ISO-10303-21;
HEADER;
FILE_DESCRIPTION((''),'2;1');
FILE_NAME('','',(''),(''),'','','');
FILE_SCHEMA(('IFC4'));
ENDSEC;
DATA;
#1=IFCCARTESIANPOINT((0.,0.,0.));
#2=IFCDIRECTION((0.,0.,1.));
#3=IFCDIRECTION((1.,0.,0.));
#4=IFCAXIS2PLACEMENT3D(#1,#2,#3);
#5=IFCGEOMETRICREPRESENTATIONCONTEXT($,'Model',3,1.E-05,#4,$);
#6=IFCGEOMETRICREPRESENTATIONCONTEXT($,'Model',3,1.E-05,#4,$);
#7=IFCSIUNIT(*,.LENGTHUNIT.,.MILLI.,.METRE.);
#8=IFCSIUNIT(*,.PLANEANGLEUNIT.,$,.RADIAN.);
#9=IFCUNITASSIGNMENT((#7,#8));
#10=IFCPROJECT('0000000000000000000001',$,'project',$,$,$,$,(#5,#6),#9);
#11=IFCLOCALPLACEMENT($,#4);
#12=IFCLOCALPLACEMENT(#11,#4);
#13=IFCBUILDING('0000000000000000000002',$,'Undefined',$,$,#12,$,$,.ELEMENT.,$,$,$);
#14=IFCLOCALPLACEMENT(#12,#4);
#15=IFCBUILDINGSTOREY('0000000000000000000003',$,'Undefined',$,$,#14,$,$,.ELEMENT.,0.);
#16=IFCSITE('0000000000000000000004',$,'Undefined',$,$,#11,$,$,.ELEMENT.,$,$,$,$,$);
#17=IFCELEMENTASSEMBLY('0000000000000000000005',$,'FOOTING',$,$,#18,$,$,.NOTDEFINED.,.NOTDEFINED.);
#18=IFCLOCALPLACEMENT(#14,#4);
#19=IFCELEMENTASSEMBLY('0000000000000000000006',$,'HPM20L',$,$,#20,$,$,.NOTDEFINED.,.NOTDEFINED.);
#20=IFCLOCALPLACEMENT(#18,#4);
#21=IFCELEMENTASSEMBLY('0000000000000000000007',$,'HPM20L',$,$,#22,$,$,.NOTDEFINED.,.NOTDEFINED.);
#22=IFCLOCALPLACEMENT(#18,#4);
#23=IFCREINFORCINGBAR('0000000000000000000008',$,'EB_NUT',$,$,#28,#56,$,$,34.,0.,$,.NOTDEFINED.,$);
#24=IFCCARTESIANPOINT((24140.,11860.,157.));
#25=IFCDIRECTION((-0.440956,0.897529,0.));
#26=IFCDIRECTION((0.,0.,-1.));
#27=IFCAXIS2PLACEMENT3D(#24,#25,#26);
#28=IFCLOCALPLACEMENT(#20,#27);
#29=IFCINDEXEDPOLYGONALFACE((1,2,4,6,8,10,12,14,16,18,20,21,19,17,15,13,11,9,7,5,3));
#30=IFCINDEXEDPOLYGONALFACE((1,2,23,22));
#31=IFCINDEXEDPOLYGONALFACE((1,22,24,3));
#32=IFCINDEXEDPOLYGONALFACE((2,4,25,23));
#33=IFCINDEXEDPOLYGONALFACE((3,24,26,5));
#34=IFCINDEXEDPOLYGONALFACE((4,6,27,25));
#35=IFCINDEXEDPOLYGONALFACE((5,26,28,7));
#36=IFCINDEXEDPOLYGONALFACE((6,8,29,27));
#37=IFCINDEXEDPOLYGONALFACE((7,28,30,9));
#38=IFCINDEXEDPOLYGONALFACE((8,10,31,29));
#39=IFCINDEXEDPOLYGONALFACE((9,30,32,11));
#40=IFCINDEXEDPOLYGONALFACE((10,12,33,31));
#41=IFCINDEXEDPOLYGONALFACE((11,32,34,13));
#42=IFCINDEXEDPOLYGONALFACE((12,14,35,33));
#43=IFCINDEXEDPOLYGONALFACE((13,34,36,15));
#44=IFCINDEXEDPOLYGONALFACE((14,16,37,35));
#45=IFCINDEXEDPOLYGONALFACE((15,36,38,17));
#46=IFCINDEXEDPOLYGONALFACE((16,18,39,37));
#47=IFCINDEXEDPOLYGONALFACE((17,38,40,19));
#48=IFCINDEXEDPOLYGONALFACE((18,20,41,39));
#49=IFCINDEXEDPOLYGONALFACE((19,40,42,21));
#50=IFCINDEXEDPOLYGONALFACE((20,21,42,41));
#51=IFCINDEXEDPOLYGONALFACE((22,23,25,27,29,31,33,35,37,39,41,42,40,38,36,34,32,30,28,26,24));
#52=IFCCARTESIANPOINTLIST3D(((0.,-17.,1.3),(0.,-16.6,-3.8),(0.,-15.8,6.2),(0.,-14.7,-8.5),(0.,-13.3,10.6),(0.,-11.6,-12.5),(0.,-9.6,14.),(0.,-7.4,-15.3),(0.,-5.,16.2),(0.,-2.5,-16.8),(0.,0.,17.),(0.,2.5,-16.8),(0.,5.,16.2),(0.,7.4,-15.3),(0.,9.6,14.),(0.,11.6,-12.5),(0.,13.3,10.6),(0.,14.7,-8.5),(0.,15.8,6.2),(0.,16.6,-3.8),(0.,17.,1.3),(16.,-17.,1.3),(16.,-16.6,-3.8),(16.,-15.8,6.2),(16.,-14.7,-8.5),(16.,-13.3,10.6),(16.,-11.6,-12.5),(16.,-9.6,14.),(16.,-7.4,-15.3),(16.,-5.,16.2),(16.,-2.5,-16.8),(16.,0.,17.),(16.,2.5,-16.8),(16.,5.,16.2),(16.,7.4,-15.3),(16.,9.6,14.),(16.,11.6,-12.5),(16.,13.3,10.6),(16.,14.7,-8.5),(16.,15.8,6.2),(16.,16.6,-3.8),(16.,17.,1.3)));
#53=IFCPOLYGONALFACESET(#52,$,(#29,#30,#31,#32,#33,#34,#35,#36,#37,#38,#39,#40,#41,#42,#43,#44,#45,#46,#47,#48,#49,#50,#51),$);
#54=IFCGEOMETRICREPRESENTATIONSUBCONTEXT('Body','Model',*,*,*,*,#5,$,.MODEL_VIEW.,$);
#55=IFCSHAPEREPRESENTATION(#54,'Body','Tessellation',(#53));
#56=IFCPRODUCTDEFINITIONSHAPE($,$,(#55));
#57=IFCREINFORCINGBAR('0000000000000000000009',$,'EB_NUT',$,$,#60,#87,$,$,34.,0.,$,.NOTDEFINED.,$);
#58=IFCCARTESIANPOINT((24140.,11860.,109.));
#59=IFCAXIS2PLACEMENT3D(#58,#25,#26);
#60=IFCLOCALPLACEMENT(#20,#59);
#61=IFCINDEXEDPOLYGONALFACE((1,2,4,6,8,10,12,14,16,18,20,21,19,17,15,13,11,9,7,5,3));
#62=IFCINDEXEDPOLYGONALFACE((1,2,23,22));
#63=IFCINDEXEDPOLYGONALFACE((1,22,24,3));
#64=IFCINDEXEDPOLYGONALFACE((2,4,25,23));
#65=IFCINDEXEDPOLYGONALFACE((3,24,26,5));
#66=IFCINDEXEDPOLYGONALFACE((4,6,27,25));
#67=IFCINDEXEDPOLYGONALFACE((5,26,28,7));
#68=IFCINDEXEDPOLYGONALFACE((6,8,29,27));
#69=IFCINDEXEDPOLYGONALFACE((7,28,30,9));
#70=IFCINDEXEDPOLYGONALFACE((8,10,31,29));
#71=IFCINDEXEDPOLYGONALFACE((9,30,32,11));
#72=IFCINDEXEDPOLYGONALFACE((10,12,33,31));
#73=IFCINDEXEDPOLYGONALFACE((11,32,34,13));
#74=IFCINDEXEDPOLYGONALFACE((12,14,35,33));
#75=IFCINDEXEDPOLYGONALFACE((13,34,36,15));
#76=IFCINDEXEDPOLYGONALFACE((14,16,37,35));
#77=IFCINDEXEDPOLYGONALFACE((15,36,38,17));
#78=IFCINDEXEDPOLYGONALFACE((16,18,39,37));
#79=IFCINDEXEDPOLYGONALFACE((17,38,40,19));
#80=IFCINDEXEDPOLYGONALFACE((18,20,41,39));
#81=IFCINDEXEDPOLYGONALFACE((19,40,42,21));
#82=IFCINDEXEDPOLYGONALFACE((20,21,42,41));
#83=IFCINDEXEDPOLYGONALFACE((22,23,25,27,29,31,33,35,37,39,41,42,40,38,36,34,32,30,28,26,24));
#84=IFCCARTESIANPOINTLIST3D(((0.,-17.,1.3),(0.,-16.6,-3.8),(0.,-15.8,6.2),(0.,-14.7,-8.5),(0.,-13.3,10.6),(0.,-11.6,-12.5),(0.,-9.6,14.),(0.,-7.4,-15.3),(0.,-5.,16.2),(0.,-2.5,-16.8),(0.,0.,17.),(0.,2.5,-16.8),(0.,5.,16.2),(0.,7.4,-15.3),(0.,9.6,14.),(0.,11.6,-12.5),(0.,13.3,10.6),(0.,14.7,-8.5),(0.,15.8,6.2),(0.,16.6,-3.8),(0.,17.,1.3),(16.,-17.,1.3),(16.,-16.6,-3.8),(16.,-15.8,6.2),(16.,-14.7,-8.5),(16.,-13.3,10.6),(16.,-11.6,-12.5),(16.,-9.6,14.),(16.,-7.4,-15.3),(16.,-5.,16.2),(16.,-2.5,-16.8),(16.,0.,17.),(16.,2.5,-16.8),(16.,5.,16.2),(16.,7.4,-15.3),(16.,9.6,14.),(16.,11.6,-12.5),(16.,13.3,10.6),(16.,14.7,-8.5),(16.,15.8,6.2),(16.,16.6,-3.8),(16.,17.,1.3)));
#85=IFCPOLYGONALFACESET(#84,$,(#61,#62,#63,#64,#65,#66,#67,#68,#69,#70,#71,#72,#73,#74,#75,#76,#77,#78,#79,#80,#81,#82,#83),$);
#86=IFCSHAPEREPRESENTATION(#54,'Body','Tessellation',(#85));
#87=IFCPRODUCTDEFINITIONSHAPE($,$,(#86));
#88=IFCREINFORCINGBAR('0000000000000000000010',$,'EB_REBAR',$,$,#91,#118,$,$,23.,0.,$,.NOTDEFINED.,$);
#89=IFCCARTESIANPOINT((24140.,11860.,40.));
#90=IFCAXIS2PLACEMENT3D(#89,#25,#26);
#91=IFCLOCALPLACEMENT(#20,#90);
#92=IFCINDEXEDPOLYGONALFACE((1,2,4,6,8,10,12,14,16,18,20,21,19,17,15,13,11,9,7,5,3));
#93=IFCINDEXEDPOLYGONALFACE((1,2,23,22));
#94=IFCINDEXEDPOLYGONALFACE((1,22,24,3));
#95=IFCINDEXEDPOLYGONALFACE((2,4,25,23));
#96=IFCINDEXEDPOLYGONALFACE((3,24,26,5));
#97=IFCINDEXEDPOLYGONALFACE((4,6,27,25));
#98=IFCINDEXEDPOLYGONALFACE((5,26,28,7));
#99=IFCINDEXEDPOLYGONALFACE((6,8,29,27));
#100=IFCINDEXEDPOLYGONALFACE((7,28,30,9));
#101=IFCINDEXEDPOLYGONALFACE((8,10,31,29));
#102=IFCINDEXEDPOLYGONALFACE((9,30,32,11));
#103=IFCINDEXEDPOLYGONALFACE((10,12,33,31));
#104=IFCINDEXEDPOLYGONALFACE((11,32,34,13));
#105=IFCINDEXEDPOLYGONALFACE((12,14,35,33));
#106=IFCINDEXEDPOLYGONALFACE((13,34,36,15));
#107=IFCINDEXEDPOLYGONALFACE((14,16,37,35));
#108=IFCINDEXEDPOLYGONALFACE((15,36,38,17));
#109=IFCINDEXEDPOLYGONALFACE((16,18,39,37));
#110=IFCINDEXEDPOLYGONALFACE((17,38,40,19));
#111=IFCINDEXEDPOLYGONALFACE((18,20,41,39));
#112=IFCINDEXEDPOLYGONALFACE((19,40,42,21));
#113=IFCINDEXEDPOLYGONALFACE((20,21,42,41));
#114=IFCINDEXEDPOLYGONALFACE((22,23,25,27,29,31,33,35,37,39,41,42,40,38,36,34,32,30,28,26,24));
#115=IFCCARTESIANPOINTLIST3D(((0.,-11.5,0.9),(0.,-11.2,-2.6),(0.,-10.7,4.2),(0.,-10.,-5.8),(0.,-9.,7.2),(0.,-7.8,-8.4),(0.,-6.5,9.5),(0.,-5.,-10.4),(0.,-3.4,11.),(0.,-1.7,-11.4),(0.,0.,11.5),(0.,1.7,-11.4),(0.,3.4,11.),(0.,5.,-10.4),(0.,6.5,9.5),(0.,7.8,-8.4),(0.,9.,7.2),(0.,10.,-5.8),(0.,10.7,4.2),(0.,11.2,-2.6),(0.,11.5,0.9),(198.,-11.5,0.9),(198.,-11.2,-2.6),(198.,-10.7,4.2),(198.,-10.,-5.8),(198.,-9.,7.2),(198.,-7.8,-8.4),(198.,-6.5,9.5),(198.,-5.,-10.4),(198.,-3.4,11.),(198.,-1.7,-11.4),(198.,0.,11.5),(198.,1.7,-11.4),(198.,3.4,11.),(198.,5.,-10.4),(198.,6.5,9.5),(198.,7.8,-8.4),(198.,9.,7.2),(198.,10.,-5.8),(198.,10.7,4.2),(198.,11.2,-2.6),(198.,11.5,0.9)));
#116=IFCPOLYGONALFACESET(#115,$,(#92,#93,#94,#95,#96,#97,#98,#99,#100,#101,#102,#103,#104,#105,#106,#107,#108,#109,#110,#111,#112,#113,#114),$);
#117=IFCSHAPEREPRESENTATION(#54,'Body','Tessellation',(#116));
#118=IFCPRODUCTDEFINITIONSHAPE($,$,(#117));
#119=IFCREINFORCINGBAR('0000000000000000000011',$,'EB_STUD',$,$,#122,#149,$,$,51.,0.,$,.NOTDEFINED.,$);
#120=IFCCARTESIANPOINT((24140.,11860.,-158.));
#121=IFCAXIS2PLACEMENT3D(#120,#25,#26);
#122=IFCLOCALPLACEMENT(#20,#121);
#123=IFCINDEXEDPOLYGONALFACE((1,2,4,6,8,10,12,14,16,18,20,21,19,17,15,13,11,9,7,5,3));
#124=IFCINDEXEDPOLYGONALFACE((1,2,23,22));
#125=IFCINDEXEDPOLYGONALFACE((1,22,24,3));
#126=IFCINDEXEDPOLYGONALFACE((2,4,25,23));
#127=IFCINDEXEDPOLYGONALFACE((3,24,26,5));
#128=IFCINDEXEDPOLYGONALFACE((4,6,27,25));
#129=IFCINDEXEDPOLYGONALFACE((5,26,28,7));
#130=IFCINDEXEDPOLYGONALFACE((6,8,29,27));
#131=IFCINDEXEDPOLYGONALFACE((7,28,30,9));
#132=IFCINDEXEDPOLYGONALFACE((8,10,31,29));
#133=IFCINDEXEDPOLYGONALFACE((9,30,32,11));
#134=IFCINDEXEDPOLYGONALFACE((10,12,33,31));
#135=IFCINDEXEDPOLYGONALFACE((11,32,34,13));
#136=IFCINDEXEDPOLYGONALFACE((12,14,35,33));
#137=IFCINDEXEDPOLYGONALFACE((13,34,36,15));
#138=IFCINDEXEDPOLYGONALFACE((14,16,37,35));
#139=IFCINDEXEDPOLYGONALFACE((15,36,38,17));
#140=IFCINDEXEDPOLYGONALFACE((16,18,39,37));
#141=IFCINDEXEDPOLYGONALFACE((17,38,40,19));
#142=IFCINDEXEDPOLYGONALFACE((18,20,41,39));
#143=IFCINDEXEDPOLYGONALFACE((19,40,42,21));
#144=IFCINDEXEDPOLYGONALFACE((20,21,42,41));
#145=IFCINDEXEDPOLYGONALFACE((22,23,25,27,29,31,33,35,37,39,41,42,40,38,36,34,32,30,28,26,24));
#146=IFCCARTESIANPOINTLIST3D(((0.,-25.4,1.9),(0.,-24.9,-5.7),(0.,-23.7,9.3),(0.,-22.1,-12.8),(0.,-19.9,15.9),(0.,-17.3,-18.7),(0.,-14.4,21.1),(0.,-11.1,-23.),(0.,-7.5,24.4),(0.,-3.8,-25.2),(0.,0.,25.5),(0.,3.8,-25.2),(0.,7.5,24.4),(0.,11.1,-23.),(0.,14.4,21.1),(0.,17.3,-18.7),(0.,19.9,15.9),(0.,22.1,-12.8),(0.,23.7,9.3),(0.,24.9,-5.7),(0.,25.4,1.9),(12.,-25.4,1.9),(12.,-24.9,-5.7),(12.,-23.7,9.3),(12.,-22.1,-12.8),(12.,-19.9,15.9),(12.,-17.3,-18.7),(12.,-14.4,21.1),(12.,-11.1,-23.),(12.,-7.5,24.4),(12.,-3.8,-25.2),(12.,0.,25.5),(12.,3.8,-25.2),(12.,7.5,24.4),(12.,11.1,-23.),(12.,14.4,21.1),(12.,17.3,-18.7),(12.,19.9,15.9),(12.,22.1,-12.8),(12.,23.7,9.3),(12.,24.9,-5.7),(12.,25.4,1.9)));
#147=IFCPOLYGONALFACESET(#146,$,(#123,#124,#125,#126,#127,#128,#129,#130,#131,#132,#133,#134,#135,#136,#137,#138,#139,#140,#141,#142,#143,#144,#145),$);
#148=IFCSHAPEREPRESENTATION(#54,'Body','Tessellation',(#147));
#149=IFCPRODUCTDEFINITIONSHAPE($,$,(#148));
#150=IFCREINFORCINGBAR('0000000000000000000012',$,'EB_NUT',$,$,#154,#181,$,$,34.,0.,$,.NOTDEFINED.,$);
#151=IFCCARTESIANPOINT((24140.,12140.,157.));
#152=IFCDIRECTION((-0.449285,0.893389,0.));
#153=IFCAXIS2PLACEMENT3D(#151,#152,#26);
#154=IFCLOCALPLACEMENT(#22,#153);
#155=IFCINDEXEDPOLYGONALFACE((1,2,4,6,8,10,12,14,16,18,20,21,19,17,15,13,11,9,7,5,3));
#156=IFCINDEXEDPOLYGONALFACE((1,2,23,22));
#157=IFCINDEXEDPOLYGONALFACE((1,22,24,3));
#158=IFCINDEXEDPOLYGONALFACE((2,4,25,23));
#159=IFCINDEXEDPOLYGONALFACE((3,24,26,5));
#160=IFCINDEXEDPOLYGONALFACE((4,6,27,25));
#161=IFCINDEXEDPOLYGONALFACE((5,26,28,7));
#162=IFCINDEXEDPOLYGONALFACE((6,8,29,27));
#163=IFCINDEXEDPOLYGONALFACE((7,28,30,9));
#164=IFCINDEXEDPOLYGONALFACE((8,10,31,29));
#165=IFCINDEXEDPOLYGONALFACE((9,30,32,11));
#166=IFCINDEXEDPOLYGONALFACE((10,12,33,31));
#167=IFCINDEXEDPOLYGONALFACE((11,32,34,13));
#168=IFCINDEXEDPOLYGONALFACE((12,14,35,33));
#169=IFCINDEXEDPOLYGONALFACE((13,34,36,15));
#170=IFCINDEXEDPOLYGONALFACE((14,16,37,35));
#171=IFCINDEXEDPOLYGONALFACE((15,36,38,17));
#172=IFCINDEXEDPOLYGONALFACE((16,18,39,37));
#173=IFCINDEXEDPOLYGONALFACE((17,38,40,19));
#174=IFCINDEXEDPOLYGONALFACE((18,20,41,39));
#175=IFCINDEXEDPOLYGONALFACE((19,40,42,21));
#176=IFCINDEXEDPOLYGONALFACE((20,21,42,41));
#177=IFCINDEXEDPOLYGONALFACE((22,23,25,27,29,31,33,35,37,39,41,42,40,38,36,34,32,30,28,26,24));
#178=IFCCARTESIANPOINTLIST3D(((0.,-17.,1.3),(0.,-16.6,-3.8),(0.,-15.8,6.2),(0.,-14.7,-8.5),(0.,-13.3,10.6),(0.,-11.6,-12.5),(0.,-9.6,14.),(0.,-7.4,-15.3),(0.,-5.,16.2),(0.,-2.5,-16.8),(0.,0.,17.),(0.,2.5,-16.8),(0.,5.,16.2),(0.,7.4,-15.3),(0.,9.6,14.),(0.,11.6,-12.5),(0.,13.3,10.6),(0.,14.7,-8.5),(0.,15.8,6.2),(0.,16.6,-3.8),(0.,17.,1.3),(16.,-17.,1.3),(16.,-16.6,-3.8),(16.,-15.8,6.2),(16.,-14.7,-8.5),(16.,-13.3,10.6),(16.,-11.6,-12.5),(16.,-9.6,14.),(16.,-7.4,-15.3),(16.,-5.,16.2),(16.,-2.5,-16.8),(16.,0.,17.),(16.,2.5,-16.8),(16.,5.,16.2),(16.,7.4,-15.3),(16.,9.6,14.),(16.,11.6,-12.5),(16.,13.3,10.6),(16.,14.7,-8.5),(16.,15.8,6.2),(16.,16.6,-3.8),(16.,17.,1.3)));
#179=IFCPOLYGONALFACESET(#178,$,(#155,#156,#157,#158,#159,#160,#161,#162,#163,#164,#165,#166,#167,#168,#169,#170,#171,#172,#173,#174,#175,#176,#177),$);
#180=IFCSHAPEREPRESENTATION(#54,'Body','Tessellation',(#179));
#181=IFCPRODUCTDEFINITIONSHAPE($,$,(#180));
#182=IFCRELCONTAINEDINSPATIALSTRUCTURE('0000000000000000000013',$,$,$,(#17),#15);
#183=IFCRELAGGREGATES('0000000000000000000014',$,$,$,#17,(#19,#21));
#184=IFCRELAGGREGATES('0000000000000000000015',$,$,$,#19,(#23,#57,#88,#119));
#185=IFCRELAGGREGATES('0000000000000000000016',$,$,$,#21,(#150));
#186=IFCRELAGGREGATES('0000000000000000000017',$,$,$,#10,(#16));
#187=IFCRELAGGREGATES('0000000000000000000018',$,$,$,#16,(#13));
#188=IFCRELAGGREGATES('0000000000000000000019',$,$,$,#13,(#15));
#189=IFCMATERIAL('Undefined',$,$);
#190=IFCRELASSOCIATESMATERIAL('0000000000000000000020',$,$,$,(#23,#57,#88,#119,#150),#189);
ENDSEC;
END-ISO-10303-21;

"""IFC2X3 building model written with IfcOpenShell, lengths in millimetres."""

from ifc_helpers import new_model, entity, si_unit, frame, origin_with_axes, place, context, subcontext, project, spatial, source, transform, mapped, material, element, aggregate, save


model = new_model("IFC2X3")

# Units and contexts
model_context_1 = context("Model", 3, precision=1e-05, world=origin_with_axes())
model_context_2 = context("Model", 3, precision=1e-05, world=origin_with_axes())
body_context = subcontext(model_context_1, "Body", "Model", "MODEL_VIEW")
ifc_project = project(units=[si_unit("LENGTHUNIT", "METRE", prefix="MILLI"), si_unit("PLANEANGLEUNIT", "RADIAN")], contexts=[model_context_1, model_context_2])

# Site, building, storey
site_placement = place(None, origin_with_axes())
site = spatial("IfcSite", under=ifc_project, at=site_placement, Name="Undefined", CompositionType="ELEMENT")
building_placement = place(site_placement, origin_with_axes())
building = spatial("IfcBuilding", under=site, at=building_placement, Name="Undefined", CompositionType="ELEMENT")
storey_placement = place(building_placement, origin_with_axes())
storey = spatial("IfcBuildingStorey", under=building, at=storey_placement, Name="Undefined", CompositionType="ELEMENT", Elevation=0.0)

# Element assembly
assembly_1_placement = place(storey_placement, origin_with_axes())
assembly_1 = element("IfcElementAssembly", 1, at=assembly_1_placement, inside=storey, Name="FOOTING", AssemblyPlace="NOTDEFINED", PredefinedType="NOTDEFINED")

# Element assembly
assembly_2_placement = place(assembly_1_placement, origin_with_axes())
assembly_2 = element("IfcElementAssembly", 2, at=assembly_2_placement, Name="HPM20L", AssemblyPlace="NOTDEFINED", PredefinedType="NOTDEFINED")

# Element assembly
assembly_3_placement = place(assembly_1_placement, origin_with_axes())
assembly_3 = element("IfcElementAssembly", 3, at=assembly_3_placement, Name="HPM20L", AssemblyPlace="NOTDEFINED", PredefinedType="NOTDEFINED")
aggregate(assembly_1, [assembly_2, assembly_3])

# Shared definitions
ifc_material_1 = material(Name="Undefined")

# Reinforcing bars
shared_shape_1 = source(origin_with_axes(), body_context, "Body", "AdvancedSweptSolid", [
    entity("IfcSweptDiskSolid", entity("IfcTrimmedCurve", entity("IfcLine", entity("IfcCartesianPoint", [0.0, 0.0, 0.0]), entity("IfcVector", entity("IfcDirection", [1.0, 0.0, 0.0]), 1.0)), [entity("IfcParameterValue", 0.0)], [entity("IfcParameterValue", 16.0)], True, "PARAMETER"), 17.0, None, 0.0, 16.0),
])
reinforcing_bar_1_placement = place(assembly_2_placement, frame((24140.0, 11860.0, 157.0), z_axis=(-0.440956, 0.897529, 0.0), x_axis=(0.0, 0.0, -1.0)))
reinforcing_bar_1 = element("IfcReinforcingBar", 4, at=reinforcing_bar_1_placement, material=ifc_material_1, Name="EB_NUT", BarRole="NOTDEFINED", CrossSectionArea=0.0, NominalDiameter=34.0, context=body_context, shape_type="MappedRepresentation", body=[
    mapped(shared_shape_1, transform((0.0, 0.0, 0.0))),
])
shared_shape_2 = source(origin_with_axes(), body_context, "Body", "AdvancedSweptSolid", [
    entity("IfcSweptDiskSolid", entity("IfcTrimmedCurve", entity("IfcLine", entity("IfcCartesianPoint", [0.0, 0.0, 0.0]), entity("IfcVector", entity("IfcDirection", [1.0, 0.0, 0.0]), 1.0)), [entity("IfcParameterValue", 0.0)], [entity("IfcParameterValue", 16.0)], True, "PARAMETER"), 17.0, None, 0.0, 16.0),
])
reinforcing_bar_2_placement = place(assembly_2_placement, frame((24140.0, 11860.0, 109.0), z_axis=(-0.440956, 0.897529, 0.0), x_axis=(0.0, 0.0, -1.0)))
reinforcing_bar_2 = element("IfcReinforcingBar", 5, at=reinforcing_bar_2_placement, material=ifc_material_1, Name="EB_NUT", BarRole="NOTDEFINED", CrossSectionArea=0.0, NominalDiameter=34.0, context=body_context, shape_type="MappedRepresentation", body=[
    mapped(shared_shape_2, transform((0.0, 0.0, 0.0))),
])
shared_shape_3 = source(origin_with_axes(), body_context, "Body", "AdvancedSweptSolid", [
    entity("IfcSweptDiskSolid", entity("IfcTrimmedCurve", entity("IfcLine", entity("IfcCartesianPoint", [0.0, 0.0, 0.0]), entity("IfcVector", entity("IfcDirection", [1.0, 0.0, 0.0]), 1.0)), [entity("IfcParameterValue", 0.0)], [entity("IfcParameterValue", 198.0)], True, "PARAMETER"), 11.5, None, 0.0, 198.0),
])
reinforcing_bar_3_placement = place(assembly_2_placement, frame((24140.0, 11860.0, 40.0), z_axis=(-0.440956, 0.897529, 0.0), x_axis=(0.0, 0.0, -1.0)))
reinforcing_bar_3 = element("IfcReinforcingBar", 6, at=reinforcing_bar_3_placement, material=ifc_material_1, Name="EB_REBAR", BarRole="NOTDEFINED", CrossSectionArea=0.0, NominalDiameter=23.0, context=body_context, shape_type="MappedRepresentation", body=[
    mapped(shared_shape_3, transform((0.0, 0.0, 0.0))),
])
shared_shape_4 = source(origin_with_axes(), body_context, "Body", "AdvancedSweptSolid", [
    entity("IfcSweptDiskSolid", entity("IfcTrimmedCurve", entity("IfcLine", entity("IfcCartesianPoint", [0.0, 0.0, 0.0]), entity("IfcVector", entity("IfcDirection", [1.0, 0.0, 0.0]), 1.0)), [entity("IfcParameterValue", 0.0)], [entity("IfcParameterValue", 12.0)], True, "PARAMETER"), 25.5, None, 0.0, 12.0),
])
reinforcing_bar_4_placement = place(assembly_2_placement, frame((24140.0, 11860.0, -158.0), z_axis=(-0.440956, 0.897529, 0.0), x_axis=(0.0, 0.0, -1.0)))
reinforcing_bar_4 = element("IfcReinforcingBar", 7, at=reinforcing_bar_4_placement, material=ifc_material_1, Name="EB_STUD", BarRole="NOTDEFINED", CrossSectionArea=0.0, NominalDiameter=51.0, context=body_context, shape_type="MappedRepresentation", body=[
    mapped(shared_shape_4, transform((0.0, 0.0, 0.0))),
])
aggregate(assembly_2, [reinforcing_bar_1, reinforcing_bar_2, reinforcing_bar_3, reinforcing_bar_4])
shared_shape_5 = source(origin_with_axes(), body_context, "Body", "AdvancedSweptSolid", [
    entity("IfcSweptDiskSolid", entity("IfcTrimmedCurve", entity("IfcLine", entity("IfcCartesianPoint", [0.0, 0.0, 0.0]), entity("IfcVector", entity("IfcDirection", [1.0, 0.0, 0.0]), 1.0)), [entity("IfcParameterValue", 0.0)], [entity("IfcParameterValue", 16.0)], True, "PARAMETER"), 17.0, None, 0.0, 16.0),
])
reinforcing_bar_5_placement = place(assembly_3_placement, frame((24140.0, 12140.0, 157.0), z_axis=(-0.449285, 0.893389, 0.0), x_axis=(0.0, 0.0, -1.0)))
reinforcing_bar_5 = element("IfcReinforcingBar", 8, at=reinforcing_bar_5_placement, material=ifc_material_1, Name="EB_NUT", BarRole="NOTDEFINED", CrossSectionArea=0.0, NominalDiameter=34.0, context=body_context, shape_type="MappedRepresentation", body=[
    mapped(shared_shape_5, transform((0.0, 0.0, 0.0))),
])
aggregate(assembly_3, [reinforcing_bar_5])

save(model, "model.ifc")
